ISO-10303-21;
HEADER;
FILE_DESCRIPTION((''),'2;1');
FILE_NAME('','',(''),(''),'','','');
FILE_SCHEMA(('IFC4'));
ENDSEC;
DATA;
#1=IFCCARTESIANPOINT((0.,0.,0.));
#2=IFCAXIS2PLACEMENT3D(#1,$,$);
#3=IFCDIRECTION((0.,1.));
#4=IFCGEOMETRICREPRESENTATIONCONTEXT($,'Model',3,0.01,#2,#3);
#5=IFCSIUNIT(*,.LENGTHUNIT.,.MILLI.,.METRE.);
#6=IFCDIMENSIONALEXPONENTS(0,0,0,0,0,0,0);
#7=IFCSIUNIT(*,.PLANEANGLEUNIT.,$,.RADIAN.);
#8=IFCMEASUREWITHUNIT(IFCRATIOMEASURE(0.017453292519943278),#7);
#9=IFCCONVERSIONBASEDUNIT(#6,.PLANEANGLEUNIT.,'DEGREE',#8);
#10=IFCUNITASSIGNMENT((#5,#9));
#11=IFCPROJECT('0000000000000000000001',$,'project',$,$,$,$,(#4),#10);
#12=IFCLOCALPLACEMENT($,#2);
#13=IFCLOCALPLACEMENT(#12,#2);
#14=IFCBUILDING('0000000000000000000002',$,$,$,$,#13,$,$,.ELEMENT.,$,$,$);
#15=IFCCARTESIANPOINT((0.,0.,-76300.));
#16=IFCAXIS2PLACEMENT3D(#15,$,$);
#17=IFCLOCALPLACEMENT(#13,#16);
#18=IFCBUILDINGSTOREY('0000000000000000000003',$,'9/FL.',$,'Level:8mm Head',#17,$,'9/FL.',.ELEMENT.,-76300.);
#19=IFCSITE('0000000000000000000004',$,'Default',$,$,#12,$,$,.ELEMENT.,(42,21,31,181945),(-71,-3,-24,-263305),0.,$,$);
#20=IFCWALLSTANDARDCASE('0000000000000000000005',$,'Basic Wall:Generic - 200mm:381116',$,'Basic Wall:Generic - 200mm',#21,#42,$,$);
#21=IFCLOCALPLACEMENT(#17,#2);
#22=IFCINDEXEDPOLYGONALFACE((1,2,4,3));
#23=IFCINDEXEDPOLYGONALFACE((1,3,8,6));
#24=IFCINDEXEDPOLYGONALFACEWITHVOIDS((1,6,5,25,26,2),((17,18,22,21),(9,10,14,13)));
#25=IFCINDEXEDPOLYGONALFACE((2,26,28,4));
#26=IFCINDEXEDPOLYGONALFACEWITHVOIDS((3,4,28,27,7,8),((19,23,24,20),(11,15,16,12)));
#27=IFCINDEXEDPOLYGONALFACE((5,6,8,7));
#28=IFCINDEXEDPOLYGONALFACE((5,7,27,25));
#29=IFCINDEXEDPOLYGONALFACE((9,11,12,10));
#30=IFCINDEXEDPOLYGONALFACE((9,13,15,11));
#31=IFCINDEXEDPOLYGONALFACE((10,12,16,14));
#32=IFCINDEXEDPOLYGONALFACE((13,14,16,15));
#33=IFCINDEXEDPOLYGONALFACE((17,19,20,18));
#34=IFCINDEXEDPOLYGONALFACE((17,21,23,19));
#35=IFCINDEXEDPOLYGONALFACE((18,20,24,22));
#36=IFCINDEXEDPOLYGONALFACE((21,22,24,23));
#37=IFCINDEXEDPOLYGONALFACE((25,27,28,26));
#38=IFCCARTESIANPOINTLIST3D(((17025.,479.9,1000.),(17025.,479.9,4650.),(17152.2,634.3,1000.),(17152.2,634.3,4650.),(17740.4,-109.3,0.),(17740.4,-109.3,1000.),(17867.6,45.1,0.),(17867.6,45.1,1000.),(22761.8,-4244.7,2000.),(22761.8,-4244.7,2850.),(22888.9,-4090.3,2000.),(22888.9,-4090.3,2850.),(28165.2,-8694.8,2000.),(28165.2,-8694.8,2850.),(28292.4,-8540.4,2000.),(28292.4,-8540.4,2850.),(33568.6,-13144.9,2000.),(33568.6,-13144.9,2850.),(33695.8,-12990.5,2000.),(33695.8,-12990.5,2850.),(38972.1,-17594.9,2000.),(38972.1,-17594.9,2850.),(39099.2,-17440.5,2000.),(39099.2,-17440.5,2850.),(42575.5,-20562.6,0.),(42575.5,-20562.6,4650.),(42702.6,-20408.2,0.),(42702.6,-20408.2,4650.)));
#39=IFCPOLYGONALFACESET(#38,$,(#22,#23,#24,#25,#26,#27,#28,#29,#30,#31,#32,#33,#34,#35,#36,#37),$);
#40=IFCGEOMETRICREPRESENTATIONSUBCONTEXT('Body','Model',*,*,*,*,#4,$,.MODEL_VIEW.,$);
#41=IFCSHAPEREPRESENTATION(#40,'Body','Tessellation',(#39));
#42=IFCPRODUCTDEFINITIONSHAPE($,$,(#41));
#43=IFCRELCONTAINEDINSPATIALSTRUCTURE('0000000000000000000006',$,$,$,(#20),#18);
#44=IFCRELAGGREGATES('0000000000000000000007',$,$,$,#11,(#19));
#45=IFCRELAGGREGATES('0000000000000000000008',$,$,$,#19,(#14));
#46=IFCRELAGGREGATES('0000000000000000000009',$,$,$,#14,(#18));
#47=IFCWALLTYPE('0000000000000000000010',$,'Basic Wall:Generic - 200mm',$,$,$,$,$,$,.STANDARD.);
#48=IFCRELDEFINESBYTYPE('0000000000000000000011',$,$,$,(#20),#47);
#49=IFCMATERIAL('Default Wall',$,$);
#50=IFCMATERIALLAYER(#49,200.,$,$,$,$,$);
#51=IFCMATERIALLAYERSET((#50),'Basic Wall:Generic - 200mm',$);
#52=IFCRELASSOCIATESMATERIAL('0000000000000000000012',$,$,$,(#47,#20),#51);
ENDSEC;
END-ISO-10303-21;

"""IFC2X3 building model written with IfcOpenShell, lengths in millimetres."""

from ifc_helpers import new_model, entity, si_unit, converted_unit, direction, frame, frame_2d, origin, origin_2d_with_axis, place, context, subcontext, project, spatial, rectangle, extrude, material, layer, layer_set, layer_usage, type_object, element, save


model = new_model("IFC2X3")

# Units and contexts
model_context = context("Model", 3, precision=0.01, world=origin(), true_north=direction((0.0, 1.0)))
body_context = subcontext(model_context, "Body", "Model", "MODEL_VIEW")
ifc_project = project(units=[si_unit("LENGTHUNIT", "METRE", prefix="MILLI"), converted_unit("PLANEANGLEUNIT", "DEGREE", entity("IfcRatioMeasure", 0.017453292519943278), si_unit("PLANEANGLEUNIT", "RADIAN"), dimensions=[0, 0, 0, 0, 0, 0, 0])], contexts=[model_context])

# Site, building, storey
site_placement = place(None, origin())
site = spatial("IfcSite", under=ifc_project, at=site_placement, Name="Default", CompositionType="ELEMENT", RefLatitude=(42, 21, 31, 181945), RefLongitude=(-71, -3, -24, -263305), RefElevation=0.0)
building_placement = place(site_placement, origin())
building = spatial("IfcBuilding", under=site, at=building_placement, CompositionType="ELEMENT")
storey_placement = place(building_placement, frame((0.0, 0.0, -76300.0)))
storey = spatial("IfcBuildingStorey", under=building, at=storey_placement, Name="9/FL.", ObjectType="Level:8mm Head", LongName="9/FL.", CompositionType="ELEMENT", Elevation=-76300.0)

# Wall, openings
ifc_material_1 = material(Name="Default Wall")
ifc_layer = layer(ifc_material_1, 200.0)
ifc_layer_set = layer_set([ifc_layer], Name="Basic Wall:Generic - 200mm")
ifc_layer_usage = layer_usage(ifc_layer_set, "AXIS2", "NEGATIVE", 100.0)
wall_type = type_object("IfcWallType", Name="Basic Wall:Generic - 200mm", PredefinedType="STANDARD", material=ifc_layer_set)
wall_1_placement = place(storey_placement, frame((42639.0, -20485.4, 0.0), z_axis=(0.0, 0.0, 1.0), x_axis=(-0.771917, 0.635723, 0.0)))
wall_1 = element("IfcWallStandardCase", 1, at=wall_1_placement, inside=storey, type_object=wall_type, material=ifc_layer_usage, Name="Basic Wall:Generic - 200mm:381116", ObjectType="Basic Wall:Generic - 200mm", context=body_context, shape_type="SweptSolid", body=[
    extrude(rectangle(XDim=33100.0, YDim=200.0, at=frame_2d((16550.0, 0.0), x_axis=(-1.0, 0.0))), origin(), (0.0, 0.0, 1.0), 4650.0),
])
opening_1_placement = place(wall_1_placement, origin())
element("IfcOpeningElement", 2, at=opening_1_placement, cuts=wall_1, ObjectType="Opening", context=body_context, shape_type="SweptSolid", body=[
    extrude(rectangle(XDim=850.0, YDim=7000.0, at=origin_2d_with_axis()), frame((8168.1, -100.0, 2425.0), z_axis=(0.0, 1.0, 0.0), x_axis=(0.0, 0.0, -1.0)), (0.0, 0.0, 1.0), 200.0),
])
opening_2_placement = place(wall_1_placement, origin())
element("IfcOpeningElement", 3, at=opening_2_placement, cuts=wall_1, ObjectType="Opening", context=body_context, shape_type="SweptSolid", body=[
    extrude(rectangle(XDim=850.0, YDim=7000.0, at=frame_2d((0.0, 0.0), x_axis=(1.0, 0.0))), frame((22168.1, -100.0, 2425.0), z_axis=(0.0, 1.0, 0.0), x_axis=(0.0, 0.0, -1.0)), (0.0, 0.0, 1.0), 200.0),
])
opening_3_placement = place(wall_1_placement, frame((45936.8, 11293.6, 0.0), z_axis=(0.0, 0.0, 1.0), x_axis=(-0.771917, -0.635723, 0.0)))
element("IfcOpeningElement", 4, at=opening_3_placement, cuts=wall_1, ObjectType="Opening", context=body_context, shape_type="SweptSolid", body=[
    extrude(rectangle(XDim=1000.0, YDim=1010.1, at=frame_2d((0.0, 0.0), x_axis=(1.0, 0.0))), frame((17485.8, 376.0, 500.0), z_axis=(-0.635723, -0.771917, 0.0), x_axis=(0.0, 0.0, -1.0)), (0.0, 0.0, 1.0), 1012.7),
])

save(model, "model.ifc")
